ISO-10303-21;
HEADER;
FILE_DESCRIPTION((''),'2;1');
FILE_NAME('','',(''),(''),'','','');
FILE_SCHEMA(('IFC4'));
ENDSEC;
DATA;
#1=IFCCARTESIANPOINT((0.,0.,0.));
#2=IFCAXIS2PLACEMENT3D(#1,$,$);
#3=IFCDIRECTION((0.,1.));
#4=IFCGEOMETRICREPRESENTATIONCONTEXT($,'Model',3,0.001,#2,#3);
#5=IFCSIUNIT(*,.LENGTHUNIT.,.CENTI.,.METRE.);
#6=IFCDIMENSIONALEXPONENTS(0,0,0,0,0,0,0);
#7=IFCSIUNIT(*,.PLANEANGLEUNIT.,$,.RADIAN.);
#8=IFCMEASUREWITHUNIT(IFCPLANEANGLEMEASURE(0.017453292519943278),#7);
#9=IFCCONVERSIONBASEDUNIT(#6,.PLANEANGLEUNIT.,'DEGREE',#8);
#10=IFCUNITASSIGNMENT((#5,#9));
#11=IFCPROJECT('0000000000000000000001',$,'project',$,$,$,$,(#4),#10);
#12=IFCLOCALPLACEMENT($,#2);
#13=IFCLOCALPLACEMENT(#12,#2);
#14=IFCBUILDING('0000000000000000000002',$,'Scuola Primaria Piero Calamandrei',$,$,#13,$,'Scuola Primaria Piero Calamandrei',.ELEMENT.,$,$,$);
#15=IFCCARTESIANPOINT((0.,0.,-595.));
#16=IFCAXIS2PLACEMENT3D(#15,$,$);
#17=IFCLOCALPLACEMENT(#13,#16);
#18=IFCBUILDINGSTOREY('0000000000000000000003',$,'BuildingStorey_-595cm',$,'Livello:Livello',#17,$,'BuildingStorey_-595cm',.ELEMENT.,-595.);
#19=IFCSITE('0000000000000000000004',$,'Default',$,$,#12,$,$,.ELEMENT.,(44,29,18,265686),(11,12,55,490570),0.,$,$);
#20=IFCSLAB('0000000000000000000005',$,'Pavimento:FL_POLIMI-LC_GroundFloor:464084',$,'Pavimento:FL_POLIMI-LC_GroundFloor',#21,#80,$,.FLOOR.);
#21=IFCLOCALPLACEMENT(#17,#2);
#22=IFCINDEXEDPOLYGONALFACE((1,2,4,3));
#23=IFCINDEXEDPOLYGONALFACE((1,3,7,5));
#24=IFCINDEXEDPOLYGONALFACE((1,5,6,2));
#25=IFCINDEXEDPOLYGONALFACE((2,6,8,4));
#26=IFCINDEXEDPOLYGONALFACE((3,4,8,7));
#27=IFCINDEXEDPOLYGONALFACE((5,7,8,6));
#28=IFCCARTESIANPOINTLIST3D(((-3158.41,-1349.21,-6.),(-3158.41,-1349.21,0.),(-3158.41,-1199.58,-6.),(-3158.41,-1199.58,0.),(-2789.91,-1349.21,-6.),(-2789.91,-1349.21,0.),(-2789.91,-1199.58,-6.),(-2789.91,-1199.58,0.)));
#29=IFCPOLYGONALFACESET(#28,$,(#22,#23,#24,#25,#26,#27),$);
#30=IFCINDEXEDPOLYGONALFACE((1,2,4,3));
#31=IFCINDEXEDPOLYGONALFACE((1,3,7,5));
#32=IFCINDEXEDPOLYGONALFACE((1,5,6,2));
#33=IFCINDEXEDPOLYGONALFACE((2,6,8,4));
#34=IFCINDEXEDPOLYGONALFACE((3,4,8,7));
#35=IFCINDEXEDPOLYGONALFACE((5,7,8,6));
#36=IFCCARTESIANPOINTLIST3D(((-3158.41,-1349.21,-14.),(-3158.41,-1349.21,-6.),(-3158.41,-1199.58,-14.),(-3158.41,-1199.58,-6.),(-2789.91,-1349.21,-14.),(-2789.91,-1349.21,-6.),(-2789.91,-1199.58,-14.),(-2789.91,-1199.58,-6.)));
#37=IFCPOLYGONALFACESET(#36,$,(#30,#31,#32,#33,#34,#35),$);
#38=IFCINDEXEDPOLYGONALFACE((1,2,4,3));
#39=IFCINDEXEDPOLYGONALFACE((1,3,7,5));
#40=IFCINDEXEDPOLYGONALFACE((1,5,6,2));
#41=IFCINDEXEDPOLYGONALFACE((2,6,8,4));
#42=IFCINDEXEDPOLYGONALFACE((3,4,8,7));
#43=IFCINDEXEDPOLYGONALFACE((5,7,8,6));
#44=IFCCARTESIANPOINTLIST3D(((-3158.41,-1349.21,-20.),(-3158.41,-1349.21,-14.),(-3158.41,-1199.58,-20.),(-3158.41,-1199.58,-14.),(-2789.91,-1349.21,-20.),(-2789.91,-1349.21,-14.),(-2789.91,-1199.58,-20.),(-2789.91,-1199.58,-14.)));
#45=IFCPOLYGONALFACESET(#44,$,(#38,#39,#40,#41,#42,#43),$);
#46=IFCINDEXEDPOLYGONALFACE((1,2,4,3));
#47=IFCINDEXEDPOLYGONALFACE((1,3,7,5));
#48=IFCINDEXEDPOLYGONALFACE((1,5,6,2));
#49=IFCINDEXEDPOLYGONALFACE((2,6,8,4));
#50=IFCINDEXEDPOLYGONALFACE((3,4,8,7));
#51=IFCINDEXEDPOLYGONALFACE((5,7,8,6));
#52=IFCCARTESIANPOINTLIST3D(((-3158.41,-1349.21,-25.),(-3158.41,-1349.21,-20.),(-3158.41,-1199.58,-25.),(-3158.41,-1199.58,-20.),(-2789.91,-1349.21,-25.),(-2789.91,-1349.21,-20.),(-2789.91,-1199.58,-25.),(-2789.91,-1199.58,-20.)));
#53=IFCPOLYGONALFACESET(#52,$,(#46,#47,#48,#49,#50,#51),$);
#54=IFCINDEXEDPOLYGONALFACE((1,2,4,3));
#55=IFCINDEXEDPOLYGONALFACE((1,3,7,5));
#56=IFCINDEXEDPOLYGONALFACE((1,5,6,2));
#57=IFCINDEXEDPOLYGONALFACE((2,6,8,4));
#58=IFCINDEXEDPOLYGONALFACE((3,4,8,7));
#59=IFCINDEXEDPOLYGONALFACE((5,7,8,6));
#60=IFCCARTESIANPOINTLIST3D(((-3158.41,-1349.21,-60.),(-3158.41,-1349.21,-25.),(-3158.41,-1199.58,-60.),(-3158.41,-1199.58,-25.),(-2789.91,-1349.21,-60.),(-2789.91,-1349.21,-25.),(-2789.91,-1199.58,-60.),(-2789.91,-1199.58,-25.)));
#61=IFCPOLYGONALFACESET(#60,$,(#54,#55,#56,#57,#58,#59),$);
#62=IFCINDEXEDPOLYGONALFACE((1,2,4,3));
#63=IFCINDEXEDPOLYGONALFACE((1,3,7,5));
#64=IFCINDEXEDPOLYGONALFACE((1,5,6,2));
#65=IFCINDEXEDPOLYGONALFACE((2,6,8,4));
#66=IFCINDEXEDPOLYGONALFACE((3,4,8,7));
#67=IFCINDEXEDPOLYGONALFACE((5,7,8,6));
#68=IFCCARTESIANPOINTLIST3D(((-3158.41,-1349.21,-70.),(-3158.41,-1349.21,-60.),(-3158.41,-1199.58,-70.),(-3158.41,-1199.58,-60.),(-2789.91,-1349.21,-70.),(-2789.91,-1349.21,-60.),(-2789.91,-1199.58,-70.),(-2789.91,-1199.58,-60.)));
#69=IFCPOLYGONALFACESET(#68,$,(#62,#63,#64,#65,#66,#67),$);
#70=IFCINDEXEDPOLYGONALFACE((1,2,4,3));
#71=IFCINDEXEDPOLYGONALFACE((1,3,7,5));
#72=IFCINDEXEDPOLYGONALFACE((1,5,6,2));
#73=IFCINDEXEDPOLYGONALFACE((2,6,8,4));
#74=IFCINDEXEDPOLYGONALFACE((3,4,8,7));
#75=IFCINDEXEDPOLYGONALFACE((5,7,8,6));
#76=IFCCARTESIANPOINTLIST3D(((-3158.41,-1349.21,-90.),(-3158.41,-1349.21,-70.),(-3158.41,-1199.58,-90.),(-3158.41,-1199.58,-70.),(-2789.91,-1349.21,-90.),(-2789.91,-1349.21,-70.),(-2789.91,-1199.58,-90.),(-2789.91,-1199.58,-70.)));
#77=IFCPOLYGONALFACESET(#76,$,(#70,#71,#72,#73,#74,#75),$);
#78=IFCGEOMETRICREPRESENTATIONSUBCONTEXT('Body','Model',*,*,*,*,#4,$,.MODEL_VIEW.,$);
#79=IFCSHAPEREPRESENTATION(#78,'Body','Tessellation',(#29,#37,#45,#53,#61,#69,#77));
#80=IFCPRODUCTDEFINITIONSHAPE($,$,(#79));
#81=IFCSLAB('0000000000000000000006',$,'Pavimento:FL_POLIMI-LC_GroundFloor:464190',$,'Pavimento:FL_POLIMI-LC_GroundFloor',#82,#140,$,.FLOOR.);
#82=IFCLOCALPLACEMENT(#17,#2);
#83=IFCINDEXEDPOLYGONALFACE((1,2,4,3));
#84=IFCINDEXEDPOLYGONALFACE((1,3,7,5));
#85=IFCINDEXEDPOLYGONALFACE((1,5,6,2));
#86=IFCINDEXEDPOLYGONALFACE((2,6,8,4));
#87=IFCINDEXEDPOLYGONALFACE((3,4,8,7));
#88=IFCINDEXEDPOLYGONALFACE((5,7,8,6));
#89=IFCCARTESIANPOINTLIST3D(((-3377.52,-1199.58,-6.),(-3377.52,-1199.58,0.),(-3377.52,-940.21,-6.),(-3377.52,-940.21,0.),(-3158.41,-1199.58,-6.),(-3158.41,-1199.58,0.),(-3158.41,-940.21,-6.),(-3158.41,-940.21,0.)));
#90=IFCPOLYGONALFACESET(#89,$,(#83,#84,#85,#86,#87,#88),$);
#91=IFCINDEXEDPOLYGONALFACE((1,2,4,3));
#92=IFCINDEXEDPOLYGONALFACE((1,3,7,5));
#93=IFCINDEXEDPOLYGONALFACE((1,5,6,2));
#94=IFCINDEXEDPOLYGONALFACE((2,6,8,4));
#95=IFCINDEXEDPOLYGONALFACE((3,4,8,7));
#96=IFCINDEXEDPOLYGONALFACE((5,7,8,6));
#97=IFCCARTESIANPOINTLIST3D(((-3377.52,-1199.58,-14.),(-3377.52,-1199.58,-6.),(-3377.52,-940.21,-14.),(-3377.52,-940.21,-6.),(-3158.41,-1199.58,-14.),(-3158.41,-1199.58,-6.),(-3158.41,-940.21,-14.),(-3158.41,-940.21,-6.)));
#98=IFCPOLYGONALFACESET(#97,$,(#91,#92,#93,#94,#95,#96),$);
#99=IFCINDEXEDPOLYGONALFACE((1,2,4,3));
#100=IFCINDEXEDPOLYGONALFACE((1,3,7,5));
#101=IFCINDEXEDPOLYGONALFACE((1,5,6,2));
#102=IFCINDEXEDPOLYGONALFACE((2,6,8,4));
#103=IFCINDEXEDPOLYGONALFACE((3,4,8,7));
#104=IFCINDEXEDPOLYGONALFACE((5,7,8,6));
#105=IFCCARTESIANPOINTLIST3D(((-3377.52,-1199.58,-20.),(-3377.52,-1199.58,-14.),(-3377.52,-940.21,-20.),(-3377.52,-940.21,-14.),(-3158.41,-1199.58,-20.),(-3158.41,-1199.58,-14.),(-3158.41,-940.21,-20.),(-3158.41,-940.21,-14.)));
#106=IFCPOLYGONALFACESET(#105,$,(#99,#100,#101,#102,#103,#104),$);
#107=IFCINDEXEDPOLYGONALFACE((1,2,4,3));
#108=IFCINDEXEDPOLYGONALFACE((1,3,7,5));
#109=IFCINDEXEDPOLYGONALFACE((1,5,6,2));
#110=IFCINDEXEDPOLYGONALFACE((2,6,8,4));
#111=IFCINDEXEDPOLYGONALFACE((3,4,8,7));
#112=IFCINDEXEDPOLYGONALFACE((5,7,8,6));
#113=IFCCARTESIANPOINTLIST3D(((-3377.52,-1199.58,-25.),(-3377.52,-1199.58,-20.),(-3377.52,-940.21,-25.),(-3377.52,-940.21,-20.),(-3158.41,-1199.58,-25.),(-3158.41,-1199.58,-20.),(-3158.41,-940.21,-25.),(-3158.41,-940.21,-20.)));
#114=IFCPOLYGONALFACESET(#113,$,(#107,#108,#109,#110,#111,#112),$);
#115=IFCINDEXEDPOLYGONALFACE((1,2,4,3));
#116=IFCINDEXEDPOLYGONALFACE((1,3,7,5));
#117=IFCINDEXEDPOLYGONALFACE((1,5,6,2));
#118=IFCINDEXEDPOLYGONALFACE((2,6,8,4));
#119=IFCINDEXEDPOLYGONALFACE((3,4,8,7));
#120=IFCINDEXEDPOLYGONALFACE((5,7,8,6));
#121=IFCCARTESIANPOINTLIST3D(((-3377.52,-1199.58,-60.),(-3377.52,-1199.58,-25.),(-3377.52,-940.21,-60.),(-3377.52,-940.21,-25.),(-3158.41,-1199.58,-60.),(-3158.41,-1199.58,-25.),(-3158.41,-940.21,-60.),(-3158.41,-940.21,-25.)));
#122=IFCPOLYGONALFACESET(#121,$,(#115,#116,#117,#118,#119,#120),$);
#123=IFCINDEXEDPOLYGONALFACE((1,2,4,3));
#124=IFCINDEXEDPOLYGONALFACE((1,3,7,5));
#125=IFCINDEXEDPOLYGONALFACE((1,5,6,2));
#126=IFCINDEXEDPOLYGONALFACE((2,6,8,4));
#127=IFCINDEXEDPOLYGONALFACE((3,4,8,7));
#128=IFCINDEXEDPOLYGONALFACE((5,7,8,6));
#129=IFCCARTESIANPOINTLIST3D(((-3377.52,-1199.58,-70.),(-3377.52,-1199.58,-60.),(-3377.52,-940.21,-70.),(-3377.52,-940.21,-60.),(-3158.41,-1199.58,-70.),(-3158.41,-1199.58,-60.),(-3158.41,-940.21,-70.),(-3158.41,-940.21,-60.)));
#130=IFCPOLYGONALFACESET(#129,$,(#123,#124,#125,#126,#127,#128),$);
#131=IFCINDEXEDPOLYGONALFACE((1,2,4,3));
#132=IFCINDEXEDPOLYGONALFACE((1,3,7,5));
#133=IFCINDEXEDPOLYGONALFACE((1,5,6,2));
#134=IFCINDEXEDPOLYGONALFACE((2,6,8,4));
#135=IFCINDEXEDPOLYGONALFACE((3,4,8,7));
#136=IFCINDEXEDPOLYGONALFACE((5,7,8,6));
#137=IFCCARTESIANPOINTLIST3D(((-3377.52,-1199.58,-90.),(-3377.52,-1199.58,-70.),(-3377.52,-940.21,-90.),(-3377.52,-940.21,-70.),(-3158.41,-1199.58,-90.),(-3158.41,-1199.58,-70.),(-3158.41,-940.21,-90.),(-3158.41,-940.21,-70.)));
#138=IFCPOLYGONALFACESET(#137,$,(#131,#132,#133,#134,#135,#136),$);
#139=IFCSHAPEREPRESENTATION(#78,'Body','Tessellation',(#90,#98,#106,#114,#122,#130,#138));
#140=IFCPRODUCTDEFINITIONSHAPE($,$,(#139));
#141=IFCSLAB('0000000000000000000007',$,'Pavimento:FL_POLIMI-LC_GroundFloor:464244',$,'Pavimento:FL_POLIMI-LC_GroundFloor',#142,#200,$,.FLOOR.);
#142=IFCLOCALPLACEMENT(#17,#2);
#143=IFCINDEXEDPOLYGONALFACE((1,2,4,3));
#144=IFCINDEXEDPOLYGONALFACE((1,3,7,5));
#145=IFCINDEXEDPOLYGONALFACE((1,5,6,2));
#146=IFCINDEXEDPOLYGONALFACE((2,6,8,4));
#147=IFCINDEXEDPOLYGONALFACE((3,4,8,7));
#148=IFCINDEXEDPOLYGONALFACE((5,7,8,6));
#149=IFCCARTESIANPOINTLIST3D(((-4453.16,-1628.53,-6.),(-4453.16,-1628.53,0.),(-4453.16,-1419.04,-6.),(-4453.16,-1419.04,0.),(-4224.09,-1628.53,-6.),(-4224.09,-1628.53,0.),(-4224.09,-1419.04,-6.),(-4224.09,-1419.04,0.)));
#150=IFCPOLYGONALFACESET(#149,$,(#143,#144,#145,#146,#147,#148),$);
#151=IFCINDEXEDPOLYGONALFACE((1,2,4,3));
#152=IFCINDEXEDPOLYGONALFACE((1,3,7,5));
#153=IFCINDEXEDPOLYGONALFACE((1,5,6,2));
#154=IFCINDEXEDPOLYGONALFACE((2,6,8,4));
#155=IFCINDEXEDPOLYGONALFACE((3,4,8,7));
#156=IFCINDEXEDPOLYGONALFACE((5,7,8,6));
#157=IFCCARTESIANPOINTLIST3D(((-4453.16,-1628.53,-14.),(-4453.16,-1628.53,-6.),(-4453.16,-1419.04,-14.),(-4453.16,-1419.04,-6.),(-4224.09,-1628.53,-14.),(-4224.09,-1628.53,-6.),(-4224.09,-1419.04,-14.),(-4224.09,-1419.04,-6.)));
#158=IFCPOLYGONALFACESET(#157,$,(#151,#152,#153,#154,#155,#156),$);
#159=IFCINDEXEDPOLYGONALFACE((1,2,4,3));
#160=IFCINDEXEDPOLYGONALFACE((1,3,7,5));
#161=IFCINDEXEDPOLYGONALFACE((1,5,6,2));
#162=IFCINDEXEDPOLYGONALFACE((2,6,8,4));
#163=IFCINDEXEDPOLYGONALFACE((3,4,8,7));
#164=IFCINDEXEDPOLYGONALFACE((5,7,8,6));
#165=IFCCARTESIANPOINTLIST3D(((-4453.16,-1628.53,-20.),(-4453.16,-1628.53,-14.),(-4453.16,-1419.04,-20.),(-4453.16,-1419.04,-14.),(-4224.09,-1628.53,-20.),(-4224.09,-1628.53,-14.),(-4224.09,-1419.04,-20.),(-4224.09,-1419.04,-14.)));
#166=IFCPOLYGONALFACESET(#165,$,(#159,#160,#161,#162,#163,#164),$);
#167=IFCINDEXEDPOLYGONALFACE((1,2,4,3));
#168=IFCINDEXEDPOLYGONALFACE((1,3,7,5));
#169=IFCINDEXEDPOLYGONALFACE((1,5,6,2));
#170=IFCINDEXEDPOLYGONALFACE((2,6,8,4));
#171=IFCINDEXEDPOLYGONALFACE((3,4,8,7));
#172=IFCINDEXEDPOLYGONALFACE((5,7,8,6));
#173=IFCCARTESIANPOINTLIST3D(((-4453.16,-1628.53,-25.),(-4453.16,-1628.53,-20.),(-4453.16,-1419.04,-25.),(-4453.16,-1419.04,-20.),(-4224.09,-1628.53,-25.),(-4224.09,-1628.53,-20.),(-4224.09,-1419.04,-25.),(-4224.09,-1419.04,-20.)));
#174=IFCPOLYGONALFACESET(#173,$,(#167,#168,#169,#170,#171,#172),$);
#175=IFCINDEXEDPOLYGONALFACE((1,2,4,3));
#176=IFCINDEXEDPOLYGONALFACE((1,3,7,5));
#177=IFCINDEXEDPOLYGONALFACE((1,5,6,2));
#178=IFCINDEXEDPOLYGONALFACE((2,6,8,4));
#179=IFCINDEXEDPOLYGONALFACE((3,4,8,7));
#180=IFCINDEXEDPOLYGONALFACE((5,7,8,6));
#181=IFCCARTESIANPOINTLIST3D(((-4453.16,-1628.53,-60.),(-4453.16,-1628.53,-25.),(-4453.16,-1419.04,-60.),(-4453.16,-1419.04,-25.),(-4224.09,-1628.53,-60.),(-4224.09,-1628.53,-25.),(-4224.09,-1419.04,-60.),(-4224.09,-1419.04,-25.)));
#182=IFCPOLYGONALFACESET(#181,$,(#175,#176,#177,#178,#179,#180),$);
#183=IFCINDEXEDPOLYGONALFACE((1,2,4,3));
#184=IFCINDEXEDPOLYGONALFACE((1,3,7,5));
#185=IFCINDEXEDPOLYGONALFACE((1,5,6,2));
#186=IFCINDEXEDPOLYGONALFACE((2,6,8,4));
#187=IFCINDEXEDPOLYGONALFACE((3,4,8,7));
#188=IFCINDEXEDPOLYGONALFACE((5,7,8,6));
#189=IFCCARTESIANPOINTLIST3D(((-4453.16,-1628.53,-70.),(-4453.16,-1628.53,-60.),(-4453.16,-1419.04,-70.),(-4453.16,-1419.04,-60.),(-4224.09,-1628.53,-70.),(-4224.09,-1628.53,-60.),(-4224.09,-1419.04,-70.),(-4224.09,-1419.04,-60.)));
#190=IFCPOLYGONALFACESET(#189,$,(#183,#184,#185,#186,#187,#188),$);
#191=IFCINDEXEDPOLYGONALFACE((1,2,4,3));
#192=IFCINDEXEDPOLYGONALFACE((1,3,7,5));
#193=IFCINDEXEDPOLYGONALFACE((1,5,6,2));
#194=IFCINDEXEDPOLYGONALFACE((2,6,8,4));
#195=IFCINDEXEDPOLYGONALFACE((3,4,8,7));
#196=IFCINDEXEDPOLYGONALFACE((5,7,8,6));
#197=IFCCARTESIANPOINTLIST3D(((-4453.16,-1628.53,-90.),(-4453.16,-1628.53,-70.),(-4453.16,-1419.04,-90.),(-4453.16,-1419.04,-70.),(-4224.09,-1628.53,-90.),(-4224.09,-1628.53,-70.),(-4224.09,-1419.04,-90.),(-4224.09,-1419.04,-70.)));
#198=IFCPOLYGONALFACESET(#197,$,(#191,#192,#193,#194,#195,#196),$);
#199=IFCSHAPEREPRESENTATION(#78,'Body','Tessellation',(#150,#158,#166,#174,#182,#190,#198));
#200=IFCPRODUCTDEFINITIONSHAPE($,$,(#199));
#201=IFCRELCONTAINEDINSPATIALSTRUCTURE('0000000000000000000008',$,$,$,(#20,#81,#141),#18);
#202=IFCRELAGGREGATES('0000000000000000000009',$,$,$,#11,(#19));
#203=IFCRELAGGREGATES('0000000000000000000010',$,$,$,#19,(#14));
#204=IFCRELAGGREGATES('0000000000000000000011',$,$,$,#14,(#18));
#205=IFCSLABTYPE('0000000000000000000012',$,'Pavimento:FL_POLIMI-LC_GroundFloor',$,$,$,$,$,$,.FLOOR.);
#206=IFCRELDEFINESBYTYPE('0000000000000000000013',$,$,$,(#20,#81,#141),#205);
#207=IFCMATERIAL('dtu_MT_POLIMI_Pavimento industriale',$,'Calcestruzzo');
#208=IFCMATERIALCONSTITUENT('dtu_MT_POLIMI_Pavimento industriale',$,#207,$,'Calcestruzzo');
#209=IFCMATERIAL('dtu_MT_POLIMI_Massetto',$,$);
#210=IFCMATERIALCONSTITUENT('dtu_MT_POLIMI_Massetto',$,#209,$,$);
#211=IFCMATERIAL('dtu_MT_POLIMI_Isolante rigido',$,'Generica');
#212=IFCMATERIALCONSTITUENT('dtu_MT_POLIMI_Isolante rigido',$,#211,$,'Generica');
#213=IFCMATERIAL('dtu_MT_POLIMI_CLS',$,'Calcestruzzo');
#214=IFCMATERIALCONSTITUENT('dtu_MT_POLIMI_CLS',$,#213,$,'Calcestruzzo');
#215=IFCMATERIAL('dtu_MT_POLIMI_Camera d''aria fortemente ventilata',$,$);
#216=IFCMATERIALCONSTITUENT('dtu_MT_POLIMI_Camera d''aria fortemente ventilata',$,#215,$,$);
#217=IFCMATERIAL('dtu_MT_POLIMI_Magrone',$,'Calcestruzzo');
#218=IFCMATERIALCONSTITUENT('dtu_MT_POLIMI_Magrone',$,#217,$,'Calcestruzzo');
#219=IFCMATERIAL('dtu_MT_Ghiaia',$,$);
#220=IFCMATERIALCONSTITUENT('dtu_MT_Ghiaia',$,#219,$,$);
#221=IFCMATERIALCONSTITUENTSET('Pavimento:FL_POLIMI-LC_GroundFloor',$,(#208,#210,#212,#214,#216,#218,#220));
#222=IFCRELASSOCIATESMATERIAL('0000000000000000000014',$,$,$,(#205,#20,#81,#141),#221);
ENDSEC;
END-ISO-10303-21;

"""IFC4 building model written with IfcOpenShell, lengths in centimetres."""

from ifc_helpers import new_model, entity, si_unit, converted_unit, direction, frame, origin, place, context, subcontext, project, spatial, indexed_curve, outline, extrude, material, constituent, constituent_set, type_object, element, save


model = new_model("IFC4")

# Units and contexts
model_context = context("Model", 3, precision=0.001, world=origin(), true_north=direction((0.0, 1.0)))
body_context = subcontext(model_context, "Body", "Model", "MODEL_VIEW")
ifc_project = project(units=[si_unit("LENGTHUNIT", "METRE", prefix="CENTI"), converted_unit("PLANEANGLEUNIT", "DEGREE", entity("IfcPlaneAngleMeasure", 0.017453292519943278), si_unit("PLANEANGLEUNIT", "RADIAN"), dimensions=[0, 0, 0, 0, 0, 0, 0])], contexts=[model_context])

# Site, building, storey
site_placement = place(None, origin())
site = spatial("IfcSite", under=ifc_project, at=site_placement, Name="Default", CompositionType="ELEMENT", RefLatitude=(44, 29, 18, 265686), RefLongitude=(11, 12, 55, 490570), RefElevation=0.0)
building_placement = place(site_placement, origin())
building = spatial("IfcBuilding", under=site, at=building_placement, Name="Scuola Primaria Piero Calamandrei", LongName="Scuola Primaria Piero Calamandrei", CompositionType="ELEMENT")
storey_placement = place(building_placement, frame((0.0, 0.0, -595.0)))
storey = spatial("IfcBuildingStorey", under=building, at=storey_placement, Name="BuildingStorey_-595cm", ObjectType="Livello:Livello", LongName="BuildingStorey_-595cm", CompositionType="ELEMENT", Elevation=-595.0)

# Slabs
ifc_material_1 = material(Name="dtu_MT_POLIMI_Pavimento industriale", Category="Calcestruzzo")
ifc_constituent_1 = constituent(ifc_material_1, Name="dtu_MT_POLIMI_Pavimento industriale", Category="Calcestruzzo")
ifc_material_2 = material(Name="dtu_MT_POLIMI_Massetto")
ifc_constituent_2 = constituent(ifc_material_2, Name="dtu_MT_POLIMI_Massetto")
ifc_material_3 = material(Name="dtu_MT_POLIMI_Isolante rigido", Category="Generica")
ifc_constituent_3 = constituent(ifc_material_3, Name="dtu_MT_POLIMI_Isolante rigido", Category="Generica")
ifc_material_4 = material(Name="dtu_MT_POLIMI_CLS", Category="Calcestruzzo")
ifc_constituent_4 = constituent(ifc_material_4, Name="dtu_MT_POLIMI_CLS", Category="Calcestruzzo")
ifc_material_5 = material(Name="dtu_MT_POLIMI_Camera d'aria fortemente ventilata")
ifc_constituent_5 = constituent(ifc_material_5, Name="dtu_MT_POLIMI_Camera d'aria fortemente ventilata")
ifc_material_6 = material(Name="dtu_MT_POLIMI_Magrone", Category="Calcestruzzo")
ifc_constituent_6 = constituent(ifc_material_6, Name="dtu_MT_POLIMI_Magrone", Category="Calcestruzzo")
ifc_material_7 = material(Name="dtu_MT_Ghiaia")
ifc_constituent_7 = constituent(ifc_material_7, Name="dtu_MT_Ghiaia")
ifc_constituent_set_1 = constituent_set(constituents=[ifc_constituent_1, ifc_constituent_2, ifc_constituent_3, ifc_constituent_4, ifc_constituent_5, ifc_constituent_6, ifc_constituent_7], Name="Pavimento:FL_POLIMI-LC_GroundFloor")
slab_type = type_object("IfcSlabType", Name="Pavimento:FL_POLIMI-LC_GroundFloor", PredefinedType="FLOOR", material=ifc_constituent_set_1)
slab_1_placement = place(storey_placement, origin())
element("IfcSlab", 1, at=slab_1_placement, inside=storey, type_object=slab_type, material=ifc_constituent_set_1, Name="Pavimento:FL_POLIMI-LC_GroundFloor:464084", ObjectType="Pavimento:FL_POLIMI-LC_GroundFloor", PredefinedType="FLOOR", context=body_context, shape_type="SweptSolid", body=[
    extrude(outline(indexed_curve([(-184.25, -74.82), (184.25, -74.82), (184.25, 74.82), (-184.25, 74.82), (-184.25, -74.82)], self_intersect=False)), frame((-2974.16, -1274.39, -6.0), z_axis=(0.0, 0.0, 1.0), x_axis=(-1.0, 0.0, 0.0)), (0.0, 0.0, 1.0), 6.0),
    extrude(outline(indexed_curve([(-184.25, -74.82), (184.25, -74.82), (184.25, 74.82), (-184.25, 74.82), (-184.25, -74.82)], self_intersect=False)), frame((-2974.16, -1274.39, -14.0), z_axis=(0.0, 0.0, 1.0), x_axis=(-1.0, 0.0, 0.0)), (0.0, 0.0, 1.0), 8.0),
    extrude(outline(indexed_curve([(-184.25, -74.82), (184.25, -74.82), (184.25, 74.82), (-184.25, 74.82), (-184.25, -74.82)], self_intersect=False)), frame((-2974.16, -1274.39, -20.0), z_axis=(0.0, 0.0, 1.0), x_axis=(-1.0, 0.0, 0.0)), (0.0, 0.0, 1.0), 6.0),
    extrude(outline(indexed_curve([(-184.25, -74.82), (184.25, -74.82), (184.25, 74.82), (-184.25, 74.82), (-184.25, -74.82)], self_intersect=False)), frame((-2974.16, -1274.39, -25.0), z_axis=(0.0, 0.0, 1.0), x_axis=(-1.0, 0.0, 0.0)), (0.0, 0.0, 1.0), 5.0),
    extrude(outline(indexed_curve([(-184.25, -74.82), (184.25, -74.82), (184.25, 74.82), (-184.25, 74.82), (-184.25, -74.82)], self_intersect=False)), frame((-2974.16, -1274.39, -60.0), z_axis=(0.0, 0.0, 1.0), x_axis=(-1.0, 0.0, 0.0)), (0.0, 0.0, 1.0), 35.0),
    extrude(outline(indexed_curve([(-184.25, -74.82), (184.25, -74.82), (184.25, 74.82), (-184.25, 74.82), (-184.25, -74.82)], self_intersect=False)), frame((-2974.16, -1274.39, -70.0), z_axis=(0.0, 0.0, 1.0), x_axis=(-1.0, 0.0, 0.0)), (0.0, 0.0, 1.0), 10.0),
    extrude(outline(indexed_curve([(-184.25, -74.82), (184.25, -74.82), (184.25, 74.82), (-184.25, 74.82), (-184.25, -74.82)], self_intersect=False)), frame((-2974.16, -1274.39, -90.0), z_axis=(0.0, 0.0, 1.0), x_axis=(-1.0, 0.0, 0.0)), (0.0, 0.0, 1.0), 20.0),
])
slab_2_placement = place(storey_placement, origin())
element("IfcSlab", 2, at=slab_2_placement, inside=storey, type_object=slab_type, material=ifc_constituent_set_1, Name="Pavimento:FL_POLIMI-LC_GroundFloor:464190", ObjectType="Pavimento:FL_POLIMI-LC_GroundFloor", PredefinedType="FLOOR", context=body_context, shape_type="SweptSolid", body=[
    extrude(outline(indexed_curve([(-109.56, -129.68), (109.56, -129.68), (109.56, 129.68), (-109.56, 129.68), (-109.56, -129.68)], self_intersect=False)), frame((-3267.97, -1069.89, -6.0)), (0.0, 0.0, 1.0), 6.0),
    extrude(outline(indexed_curve([(-109.56, -129.68), (109.56, -129.68), (109.56, 129.68), (-109.56, 129.68), (-109.56, -129.68)], self_intersect=False)), frame((-3267.97, -1069.89, -14.0)), (0.0, 0.0, 1.0), 8.0),
    extrude(outline(indexed_curve([(-109.56, -129.68), (109.56, -129.68), (109.56, 129.68), (-109.56, 129.68), (-109.56, -129.68)], self_intersect=False)), frame((-3267.97, -1069.89, -20.0)), (0.0, 0.0, 1.0), 6.0),
    extrude(outline(indexed_curve([(-109.56, -129.68), (109.56, -129.68), (109.56, 129.68), (-109.56, 129.68), (-109.56, -129.68)], self_intersect=False)), frame((-3267.97, -1069.89, -25.0)), (0.0, 0.0, 1.0), 5.0),
    extrude(outline(indexed_curve([(-109.56, -129.68), (109.56, -129.68), (109.56, 129.68), (-109.56, 129.68), (-109.56, -129.68)], self_intersect=False)), frame((-3267.97, -1069.89, -60.0)), (0.0, 0.0, 1.0), 35.0),
    extrude(outline(indexed_curve([(-109.56, -129.68), (109.56, -129.68), (109.56, 129.68), (-109.56, 129.68), (-109.56, -129.68)], self_intersect=False)), frame((-3267.97, -1069.89, -70.0)), (0.0, 0.0, 1.0), 10.0),
    extrude(outline(indexed_curve([(-109.56, -129.68), (109.56, -129.68), (109.56, 129.68), (-109.56, 129.68), (-109.56, -129.68)], self_intersect=False)), frame((-3267.97, -1069.89, -90.0)), (0.0, 0.0, 1.0), 20.0),
])
slab_3_placement = place(storey_placement, origin())
element("IfcSlab", 3, at=slab_3_placement, inside=storey, type_object=slab_type, material=ifc_constituent_set_1, Name="Pavimento:FL_POLIMI-LC_GroundFloor:464244", ObjectType="Pavimento:FL_POLIMI-LC_GroundFloor", PredefinedType="FLOOR", context=body_context, shape_type="SweptSolid", body=[
    extrude(outline(indexed_curve([(-114.54, -104.74), (114.54, -104.74), (114.54, 104.74), (-114.54, 104.74), (-114.54, -104.74)], self_intersect=False)), frame((-4338.63, -1523.78, -6.0)), (0.0, 0.0, 1.0), 6.0),
    extrude(outline(indexed_curve([(-114.54, -104.74), (114.54, -104.74), (114.54, 104.74), (-114.54, 104.74), (-114.54, -104.74)], self_intersect=False)), frame((-4338.63, -1523.78, -14.0)), (0.0, 0.0, 1.0), 8.0),
    extrude(outline(indexed_curve([(-114.54, -104.74), (114.54, -104.74), (114.54, 104.74), (-114.54, 104.74), (-114.54, -104.74)], self_intersect=False)), frame((-4338.63, -1523.78, -20.0)), (0.0, 0.0, 1.0), 6.0),
    extrude(outline(indexed_curve([(-114.54, -104.74), (114.54, -104.74), (114.54, 104.74), (-114.54, 104.74), (-114.54, -104.74)], self_intersect=False)), frame((-4338.63, -1523.78, -25.0)), (0.0, 0.0, 1.0), 5.0),
    extrude(outline(indexed_curve([(-114.54, -104.74), (114.54, -104.74), (114.54, 104.74), (-114.54, 104.74), (-114.54, -104.74)], self_intersect=False)), frame((-4338.63, -1523.78, -60.0)), (0.0, 0.0, 1.0), 35.0),
    extrude(outline(indexed_curve([(-114.54, -104.74), (114.54, -104.74), (114.54, 104.74), (-114.54, 104.74), (-114.54, -104.74)], self_intersect=False)), frame((-4338.63, -1523.78, -70.0)), (0.0, 0.0, 1.0), 10.0),
    extrude(outline(indexed_curve([(-114.54, -104.74), (114.54, -104.74), (114.54, 104.74), (-114.54, 104.74), (-114.54, -104.74)], self_intersect=False)), frame((-4338.63, -1523.78, -90.0)), (0.0, 0.0, 1.0), 20.0),
])

save(model, "model.ifc")
